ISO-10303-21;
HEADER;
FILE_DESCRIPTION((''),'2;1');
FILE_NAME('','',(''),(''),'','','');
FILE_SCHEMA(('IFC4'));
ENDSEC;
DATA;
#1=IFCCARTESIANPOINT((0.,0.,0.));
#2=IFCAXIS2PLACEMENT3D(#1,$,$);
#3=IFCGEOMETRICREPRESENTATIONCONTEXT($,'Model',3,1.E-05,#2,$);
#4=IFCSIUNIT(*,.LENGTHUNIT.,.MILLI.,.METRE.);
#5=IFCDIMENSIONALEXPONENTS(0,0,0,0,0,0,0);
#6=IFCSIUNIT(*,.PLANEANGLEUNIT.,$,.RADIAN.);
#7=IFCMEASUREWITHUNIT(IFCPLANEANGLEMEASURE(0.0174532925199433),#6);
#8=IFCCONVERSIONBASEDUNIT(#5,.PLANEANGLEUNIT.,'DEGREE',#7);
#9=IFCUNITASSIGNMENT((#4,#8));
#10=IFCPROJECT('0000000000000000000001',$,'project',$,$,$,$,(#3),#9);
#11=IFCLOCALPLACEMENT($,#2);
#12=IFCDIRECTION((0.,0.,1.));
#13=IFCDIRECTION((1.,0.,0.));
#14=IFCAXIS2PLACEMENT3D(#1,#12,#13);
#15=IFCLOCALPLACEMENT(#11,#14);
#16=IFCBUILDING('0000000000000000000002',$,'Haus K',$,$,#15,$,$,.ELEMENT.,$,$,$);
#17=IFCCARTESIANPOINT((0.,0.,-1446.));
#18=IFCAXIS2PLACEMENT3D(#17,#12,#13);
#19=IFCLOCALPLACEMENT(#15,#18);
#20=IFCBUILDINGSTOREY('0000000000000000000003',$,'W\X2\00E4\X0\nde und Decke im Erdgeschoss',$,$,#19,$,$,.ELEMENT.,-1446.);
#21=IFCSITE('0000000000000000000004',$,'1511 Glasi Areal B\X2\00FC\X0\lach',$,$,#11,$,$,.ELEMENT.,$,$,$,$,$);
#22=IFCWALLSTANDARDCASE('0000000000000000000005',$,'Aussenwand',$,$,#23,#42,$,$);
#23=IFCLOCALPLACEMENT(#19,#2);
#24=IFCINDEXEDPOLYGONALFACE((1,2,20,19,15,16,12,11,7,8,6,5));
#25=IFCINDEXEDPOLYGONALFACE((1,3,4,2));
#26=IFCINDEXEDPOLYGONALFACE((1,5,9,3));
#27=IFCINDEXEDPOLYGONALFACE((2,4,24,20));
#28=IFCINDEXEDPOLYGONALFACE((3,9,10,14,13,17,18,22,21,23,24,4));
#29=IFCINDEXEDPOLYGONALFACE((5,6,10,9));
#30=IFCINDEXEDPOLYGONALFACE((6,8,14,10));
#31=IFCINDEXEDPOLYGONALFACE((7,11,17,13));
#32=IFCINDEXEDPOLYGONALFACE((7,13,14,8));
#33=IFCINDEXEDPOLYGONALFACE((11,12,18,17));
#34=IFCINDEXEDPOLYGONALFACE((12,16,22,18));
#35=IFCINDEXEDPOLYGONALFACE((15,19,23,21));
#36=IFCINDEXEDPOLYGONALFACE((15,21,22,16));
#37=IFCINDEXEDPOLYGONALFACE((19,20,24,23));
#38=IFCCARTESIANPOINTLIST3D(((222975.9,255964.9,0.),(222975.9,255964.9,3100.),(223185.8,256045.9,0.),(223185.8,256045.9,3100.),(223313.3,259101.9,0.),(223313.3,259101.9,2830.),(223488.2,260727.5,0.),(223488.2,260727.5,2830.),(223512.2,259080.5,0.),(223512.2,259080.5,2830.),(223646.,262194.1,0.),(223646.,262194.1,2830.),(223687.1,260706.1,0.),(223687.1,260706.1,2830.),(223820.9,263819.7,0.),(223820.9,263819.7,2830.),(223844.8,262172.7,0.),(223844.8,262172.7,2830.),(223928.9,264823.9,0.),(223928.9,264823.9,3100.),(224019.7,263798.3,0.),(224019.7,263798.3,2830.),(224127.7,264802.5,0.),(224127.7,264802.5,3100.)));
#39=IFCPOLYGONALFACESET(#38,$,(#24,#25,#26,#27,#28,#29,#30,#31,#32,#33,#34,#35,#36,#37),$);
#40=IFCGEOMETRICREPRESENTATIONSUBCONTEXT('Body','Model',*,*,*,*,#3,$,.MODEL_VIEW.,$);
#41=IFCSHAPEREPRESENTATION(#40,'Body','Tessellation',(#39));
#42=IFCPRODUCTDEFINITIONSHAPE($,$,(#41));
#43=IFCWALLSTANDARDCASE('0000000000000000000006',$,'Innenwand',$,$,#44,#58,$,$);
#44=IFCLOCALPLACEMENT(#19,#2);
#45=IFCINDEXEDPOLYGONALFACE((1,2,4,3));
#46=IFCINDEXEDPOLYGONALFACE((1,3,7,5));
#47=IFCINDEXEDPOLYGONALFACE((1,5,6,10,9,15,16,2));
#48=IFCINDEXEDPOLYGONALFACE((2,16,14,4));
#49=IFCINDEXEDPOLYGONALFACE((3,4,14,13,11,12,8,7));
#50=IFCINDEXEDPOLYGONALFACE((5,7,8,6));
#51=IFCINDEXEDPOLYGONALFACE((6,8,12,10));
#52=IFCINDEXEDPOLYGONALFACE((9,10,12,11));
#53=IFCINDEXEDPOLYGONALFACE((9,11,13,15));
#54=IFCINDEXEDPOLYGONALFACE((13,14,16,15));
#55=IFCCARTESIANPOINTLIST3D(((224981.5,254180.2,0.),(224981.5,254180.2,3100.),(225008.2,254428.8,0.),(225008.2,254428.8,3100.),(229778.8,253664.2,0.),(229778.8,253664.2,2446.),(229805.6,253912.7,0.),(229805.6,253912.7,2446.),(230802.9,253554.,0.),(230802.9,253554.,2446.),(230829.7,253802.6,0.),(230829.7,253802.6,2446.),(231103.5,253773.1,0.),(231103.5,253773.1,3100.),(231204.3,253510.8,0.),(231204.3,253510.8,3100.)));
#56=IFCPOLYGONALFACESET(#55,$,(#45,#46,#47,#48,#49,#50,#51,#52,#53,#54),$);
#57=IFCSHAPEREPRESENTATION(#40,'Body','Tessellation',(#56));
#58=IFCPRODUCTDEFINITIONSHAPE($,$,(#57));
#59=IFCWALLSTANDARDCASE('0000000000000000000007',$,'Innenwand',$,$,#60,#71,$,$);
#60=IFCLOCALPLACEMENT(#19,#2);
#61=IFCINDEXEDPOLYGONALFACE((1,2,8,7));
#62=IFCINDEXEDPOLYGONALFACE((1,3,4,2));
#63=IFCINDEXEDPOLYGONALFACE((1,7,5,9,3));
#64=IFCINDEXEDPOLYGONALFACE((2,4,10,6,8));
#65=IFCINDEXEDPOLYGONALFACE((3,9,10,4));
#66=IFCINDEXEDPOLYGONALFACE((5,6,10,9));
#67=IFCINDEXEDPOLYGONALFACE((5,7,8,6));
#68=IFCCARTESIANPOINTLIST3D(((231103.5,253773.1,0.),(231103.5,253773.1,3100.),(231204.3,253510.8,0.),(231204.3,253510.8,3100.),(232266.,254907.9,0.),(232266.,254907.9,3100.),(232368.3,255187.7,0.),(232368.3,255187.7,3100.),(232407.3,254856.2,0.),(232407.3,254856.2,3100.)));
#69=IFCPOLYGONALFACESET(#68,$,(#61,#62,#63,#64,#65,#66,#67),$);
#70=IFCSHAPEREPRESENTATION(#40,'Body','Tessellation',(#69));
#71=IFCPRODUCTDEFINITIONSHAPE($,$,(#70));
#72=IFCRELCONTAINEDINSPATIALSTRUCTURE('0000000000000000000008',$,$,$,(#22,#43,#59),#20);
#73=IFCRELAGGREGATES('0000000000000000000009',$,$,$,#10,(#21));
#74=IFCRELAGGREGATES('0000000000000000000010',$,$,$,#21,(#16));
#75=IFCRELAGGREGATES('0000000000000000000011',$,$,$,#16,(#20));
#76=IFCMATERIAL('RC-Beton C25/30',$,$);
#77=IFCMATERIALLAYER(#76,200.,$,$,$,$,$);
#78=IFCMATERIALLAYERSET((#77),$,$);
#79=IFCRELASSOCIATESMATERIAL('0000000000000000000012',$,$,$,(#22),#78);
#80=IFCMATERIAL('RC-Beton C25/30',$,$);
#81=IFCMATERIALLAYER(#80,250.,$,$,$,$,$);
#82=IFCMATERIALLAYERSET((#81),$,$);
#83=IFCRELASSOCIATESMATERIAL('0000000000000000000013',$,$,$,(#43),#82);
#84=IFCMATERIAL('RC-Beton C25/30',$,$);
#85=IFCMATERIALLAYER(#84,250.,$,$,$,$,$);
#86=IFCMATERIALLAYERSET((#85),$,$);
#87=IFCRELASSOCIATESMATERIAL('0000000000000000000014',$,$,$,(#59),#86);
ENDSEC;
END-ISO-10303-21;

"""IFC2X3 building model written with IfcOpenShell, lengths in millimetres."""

from ifc_helpers import new_model, entity, si_unit, converted_unit, frame, frame_2d, origin, origin_with_axes, place, context, subcontext, project, spatial, polyline, rectangle, outline, extrude, material, layer, layer_set, layer_usage, element, save


model = new_model("IFC2X3")

# Units and contexts
model_context = context("Model", 3, precision=1e-05, world=origin())
body_context = subcontext(model_context, "Body", "Model", "MODEL_VIEW")
ifc_project = project(units=[si_unit("LENGTHUNIT", "METRE", prefix="MILLI"), converted_unit("PLANEANGLEUNIT", "DEGREE", entity("IfcPlaneAngleMeasure", 0.0174532925199433), si_unit("PLANEANGLEUNIT", "RADIAN"), dimensions=[0, 0, 0, 0, 0, 0, 0])], contexts=[model_context])

# Site, building, storey
site_placement = place(None, origin())
site = spatial("IfcSite", under=ifc_project, at=site_placement, Name="1511 Glasi Areal Bülach", CompositionType="ELEMENT")
building_placement = place(site_placement, origin_with_axes())
building = spatial("IfcBuilding", under=site, at=building_placement, Name="Haus K", CompositionType="ELEMENT")
storey_placement = place(building_placement, frame((0.0, 0.0, -1446.0), z_axis=(0.0, 0.0, 1.0), x_axis=(1.0, 0.0, 0.0)))
storey = spatial("IfcBuildingStorey", under=building, at=storey_placement, Name="Wände und Decke im Erdgeschoss", CompositionType="ELEMENT", Elevation=-1446.0)

# Wall, openings
ifc_material_1 = material(Name="RC-Beton C25/30")
ifc_layer_1 = layer(ifc_material_1, 200.0)
ifc_layer_set_1 = layer_set([ifc_layer_1])
ifc_layer_usage_1 = layer_usage(ifc_layer_set_1, "AXIS2", "POSITIVE", 0.0)
wall_1_placement = place(storey_placement, frame((223928.9, 264823.9, 0.0), z_axis=(0.0, 0.0, 1.0), x_axis=(-0.106958, -0.994264, 0.0)))
wall_1 = element("IfcWallStandardCase", 1, at=wall_1_placement, inside=storey, material=ifc_layer_usage_1, Name="Aussenwand", context=body_context, shape_type="SweptSolid", body=[
    extrude(outline(polyline([(0.0, 0.0), (8910.1, 0.0), (8807.1, 200.0), (0.0, 200.0), (0.0, 0.0)])), origin_with_axes(), (0.0, 0.0, 1.0), 3100.0),
])
opening_1_placement = place(wall_1_placement, frame((4120.0, 0.0, 0.0), z_axis=(0.0, 1.0, 0.0), x_axis=(0.0, 0.0, 1.0)))
element("IfcOpeningElement", 2, at=opening_1_placement, cuts=wall_1, ObjectType="Opening", context=body_context, shape_type="SweptSolid", body=[
    extrude(rectangle(XDim=2830.0, YDim=1635.0, at=frame_2d((1415.0, 817.5), x_axis=(1.0, 0.0))), origin_with_axes(), (0.0, 0.0, 1.0), 200.0),
])
opening_2_placement = place(wall_1_placement, frame((1010.0, 0.0, 0.0), z_axis=(0.0, 1.0, 0.0), x_axis=(0.0, 0.0, 1.0)))
element("IfcOpeningElement", 3, at=opening_2_placement, cuts=wall_1, ObjectType="Opening", context=body_context, shape_type="SweptSolid", body=[
    extrude(rectangle(XDim=2830.0, YDim=1635.0, at=frame_2d((1415.0, 817.5), x_axis=(1.0, 0.0))), origin_with_axes(), (0.0, 0.0, 1.0), 200.0),
])

# Wall, opening
ifc_material_2 = material(Name="RC-Beton C25/30")
ifc_layer_2 = layer(ifc_material_2, 250.0)
ifc_layer_set_2 = layer_set([ifc_layer_2])
ifc_layer_usage_2 = layer_usage(ifc_layer_set_2, "AXIS2", "POSITIVE", 0.0)
wall_2_placement = place(storey_placement, frame((224981.5, 254180.2, 0.0), z_axis=(0.0, 0.0, 1.0), x_axis=(0.994264, -0.106958, 0.0)))
wall_2 = element("IfcWallStandardCase", 4, at=wall_2_placement, inside=storey, material=ifc_layer_usage_2, Name="Innenwand", context=body_context, shape_type="SweptSolid", body=[
    extrude(outline(polyline([(0.0, 0.0), (6258.7, 0.0), (6130.4, 250.0), (0.0, 250.0), (0.0, 0.0)])), origin_with_axes(), (0.0, 0.0, 1.0), 3100.0),
])
opening_3_placement = place(wall_2_placement, frame((4825.0, 0.0, 0.0), z_axis=(0.0, 1.0, 0.0), x_axis=(0.0, 0.0, 1.0)))
element("IfcOpeningElement", 5, at=opening_3_placement, cuts=wall_2, ObjectType="Opening", context=body_context, shape_type="SweptSolid", body=[
    extrude(rectangle(XDim=2446.0, YDim=1030.0, at=frame_2d((1223.0, 515.0), x_axis=(1.0, 0.0))), origin_with_axes(), (0.0, 0.0, 1.0), 250.0),
])

# Wall
ifc_material_3 = material(Name="RC-Beton C25/30")
ifc_layer_3 = layer(ifc_material_3, 250.0)
ifc_layer_set_3 = layer_set([ifc_layer_3])
ifc_layer_usage_3 = layer_usage(ifc_layer_set_3, "AXIS2", "POSITIVE", 0.0)
wall_3_placement = place(storey_placement, frame((231204.3, 253510.8, 0.0), z_axis=(0.0, 0.0, 1.0), x_axis=(0.666532, 0.745476, 0.0)))
element("IfcWallStandardCase", 6, at=wall_3_placement, inside=storey, material=ifc_layer_usage_3, Name="Innenwand", context=body_context, shape_type="SweptSolid", body=[
    extrude(outline(polyline([(0.0, 0.0), (1804.7, 0.0), (1749.1, 139.7), (2025.9, 250.0), (128.3, 250.0), (0.0, 0.0)])), origin_with_axes(), (0.0, 0.0, 1.0), 3100.0),
])

save(model, "model.ifc")
